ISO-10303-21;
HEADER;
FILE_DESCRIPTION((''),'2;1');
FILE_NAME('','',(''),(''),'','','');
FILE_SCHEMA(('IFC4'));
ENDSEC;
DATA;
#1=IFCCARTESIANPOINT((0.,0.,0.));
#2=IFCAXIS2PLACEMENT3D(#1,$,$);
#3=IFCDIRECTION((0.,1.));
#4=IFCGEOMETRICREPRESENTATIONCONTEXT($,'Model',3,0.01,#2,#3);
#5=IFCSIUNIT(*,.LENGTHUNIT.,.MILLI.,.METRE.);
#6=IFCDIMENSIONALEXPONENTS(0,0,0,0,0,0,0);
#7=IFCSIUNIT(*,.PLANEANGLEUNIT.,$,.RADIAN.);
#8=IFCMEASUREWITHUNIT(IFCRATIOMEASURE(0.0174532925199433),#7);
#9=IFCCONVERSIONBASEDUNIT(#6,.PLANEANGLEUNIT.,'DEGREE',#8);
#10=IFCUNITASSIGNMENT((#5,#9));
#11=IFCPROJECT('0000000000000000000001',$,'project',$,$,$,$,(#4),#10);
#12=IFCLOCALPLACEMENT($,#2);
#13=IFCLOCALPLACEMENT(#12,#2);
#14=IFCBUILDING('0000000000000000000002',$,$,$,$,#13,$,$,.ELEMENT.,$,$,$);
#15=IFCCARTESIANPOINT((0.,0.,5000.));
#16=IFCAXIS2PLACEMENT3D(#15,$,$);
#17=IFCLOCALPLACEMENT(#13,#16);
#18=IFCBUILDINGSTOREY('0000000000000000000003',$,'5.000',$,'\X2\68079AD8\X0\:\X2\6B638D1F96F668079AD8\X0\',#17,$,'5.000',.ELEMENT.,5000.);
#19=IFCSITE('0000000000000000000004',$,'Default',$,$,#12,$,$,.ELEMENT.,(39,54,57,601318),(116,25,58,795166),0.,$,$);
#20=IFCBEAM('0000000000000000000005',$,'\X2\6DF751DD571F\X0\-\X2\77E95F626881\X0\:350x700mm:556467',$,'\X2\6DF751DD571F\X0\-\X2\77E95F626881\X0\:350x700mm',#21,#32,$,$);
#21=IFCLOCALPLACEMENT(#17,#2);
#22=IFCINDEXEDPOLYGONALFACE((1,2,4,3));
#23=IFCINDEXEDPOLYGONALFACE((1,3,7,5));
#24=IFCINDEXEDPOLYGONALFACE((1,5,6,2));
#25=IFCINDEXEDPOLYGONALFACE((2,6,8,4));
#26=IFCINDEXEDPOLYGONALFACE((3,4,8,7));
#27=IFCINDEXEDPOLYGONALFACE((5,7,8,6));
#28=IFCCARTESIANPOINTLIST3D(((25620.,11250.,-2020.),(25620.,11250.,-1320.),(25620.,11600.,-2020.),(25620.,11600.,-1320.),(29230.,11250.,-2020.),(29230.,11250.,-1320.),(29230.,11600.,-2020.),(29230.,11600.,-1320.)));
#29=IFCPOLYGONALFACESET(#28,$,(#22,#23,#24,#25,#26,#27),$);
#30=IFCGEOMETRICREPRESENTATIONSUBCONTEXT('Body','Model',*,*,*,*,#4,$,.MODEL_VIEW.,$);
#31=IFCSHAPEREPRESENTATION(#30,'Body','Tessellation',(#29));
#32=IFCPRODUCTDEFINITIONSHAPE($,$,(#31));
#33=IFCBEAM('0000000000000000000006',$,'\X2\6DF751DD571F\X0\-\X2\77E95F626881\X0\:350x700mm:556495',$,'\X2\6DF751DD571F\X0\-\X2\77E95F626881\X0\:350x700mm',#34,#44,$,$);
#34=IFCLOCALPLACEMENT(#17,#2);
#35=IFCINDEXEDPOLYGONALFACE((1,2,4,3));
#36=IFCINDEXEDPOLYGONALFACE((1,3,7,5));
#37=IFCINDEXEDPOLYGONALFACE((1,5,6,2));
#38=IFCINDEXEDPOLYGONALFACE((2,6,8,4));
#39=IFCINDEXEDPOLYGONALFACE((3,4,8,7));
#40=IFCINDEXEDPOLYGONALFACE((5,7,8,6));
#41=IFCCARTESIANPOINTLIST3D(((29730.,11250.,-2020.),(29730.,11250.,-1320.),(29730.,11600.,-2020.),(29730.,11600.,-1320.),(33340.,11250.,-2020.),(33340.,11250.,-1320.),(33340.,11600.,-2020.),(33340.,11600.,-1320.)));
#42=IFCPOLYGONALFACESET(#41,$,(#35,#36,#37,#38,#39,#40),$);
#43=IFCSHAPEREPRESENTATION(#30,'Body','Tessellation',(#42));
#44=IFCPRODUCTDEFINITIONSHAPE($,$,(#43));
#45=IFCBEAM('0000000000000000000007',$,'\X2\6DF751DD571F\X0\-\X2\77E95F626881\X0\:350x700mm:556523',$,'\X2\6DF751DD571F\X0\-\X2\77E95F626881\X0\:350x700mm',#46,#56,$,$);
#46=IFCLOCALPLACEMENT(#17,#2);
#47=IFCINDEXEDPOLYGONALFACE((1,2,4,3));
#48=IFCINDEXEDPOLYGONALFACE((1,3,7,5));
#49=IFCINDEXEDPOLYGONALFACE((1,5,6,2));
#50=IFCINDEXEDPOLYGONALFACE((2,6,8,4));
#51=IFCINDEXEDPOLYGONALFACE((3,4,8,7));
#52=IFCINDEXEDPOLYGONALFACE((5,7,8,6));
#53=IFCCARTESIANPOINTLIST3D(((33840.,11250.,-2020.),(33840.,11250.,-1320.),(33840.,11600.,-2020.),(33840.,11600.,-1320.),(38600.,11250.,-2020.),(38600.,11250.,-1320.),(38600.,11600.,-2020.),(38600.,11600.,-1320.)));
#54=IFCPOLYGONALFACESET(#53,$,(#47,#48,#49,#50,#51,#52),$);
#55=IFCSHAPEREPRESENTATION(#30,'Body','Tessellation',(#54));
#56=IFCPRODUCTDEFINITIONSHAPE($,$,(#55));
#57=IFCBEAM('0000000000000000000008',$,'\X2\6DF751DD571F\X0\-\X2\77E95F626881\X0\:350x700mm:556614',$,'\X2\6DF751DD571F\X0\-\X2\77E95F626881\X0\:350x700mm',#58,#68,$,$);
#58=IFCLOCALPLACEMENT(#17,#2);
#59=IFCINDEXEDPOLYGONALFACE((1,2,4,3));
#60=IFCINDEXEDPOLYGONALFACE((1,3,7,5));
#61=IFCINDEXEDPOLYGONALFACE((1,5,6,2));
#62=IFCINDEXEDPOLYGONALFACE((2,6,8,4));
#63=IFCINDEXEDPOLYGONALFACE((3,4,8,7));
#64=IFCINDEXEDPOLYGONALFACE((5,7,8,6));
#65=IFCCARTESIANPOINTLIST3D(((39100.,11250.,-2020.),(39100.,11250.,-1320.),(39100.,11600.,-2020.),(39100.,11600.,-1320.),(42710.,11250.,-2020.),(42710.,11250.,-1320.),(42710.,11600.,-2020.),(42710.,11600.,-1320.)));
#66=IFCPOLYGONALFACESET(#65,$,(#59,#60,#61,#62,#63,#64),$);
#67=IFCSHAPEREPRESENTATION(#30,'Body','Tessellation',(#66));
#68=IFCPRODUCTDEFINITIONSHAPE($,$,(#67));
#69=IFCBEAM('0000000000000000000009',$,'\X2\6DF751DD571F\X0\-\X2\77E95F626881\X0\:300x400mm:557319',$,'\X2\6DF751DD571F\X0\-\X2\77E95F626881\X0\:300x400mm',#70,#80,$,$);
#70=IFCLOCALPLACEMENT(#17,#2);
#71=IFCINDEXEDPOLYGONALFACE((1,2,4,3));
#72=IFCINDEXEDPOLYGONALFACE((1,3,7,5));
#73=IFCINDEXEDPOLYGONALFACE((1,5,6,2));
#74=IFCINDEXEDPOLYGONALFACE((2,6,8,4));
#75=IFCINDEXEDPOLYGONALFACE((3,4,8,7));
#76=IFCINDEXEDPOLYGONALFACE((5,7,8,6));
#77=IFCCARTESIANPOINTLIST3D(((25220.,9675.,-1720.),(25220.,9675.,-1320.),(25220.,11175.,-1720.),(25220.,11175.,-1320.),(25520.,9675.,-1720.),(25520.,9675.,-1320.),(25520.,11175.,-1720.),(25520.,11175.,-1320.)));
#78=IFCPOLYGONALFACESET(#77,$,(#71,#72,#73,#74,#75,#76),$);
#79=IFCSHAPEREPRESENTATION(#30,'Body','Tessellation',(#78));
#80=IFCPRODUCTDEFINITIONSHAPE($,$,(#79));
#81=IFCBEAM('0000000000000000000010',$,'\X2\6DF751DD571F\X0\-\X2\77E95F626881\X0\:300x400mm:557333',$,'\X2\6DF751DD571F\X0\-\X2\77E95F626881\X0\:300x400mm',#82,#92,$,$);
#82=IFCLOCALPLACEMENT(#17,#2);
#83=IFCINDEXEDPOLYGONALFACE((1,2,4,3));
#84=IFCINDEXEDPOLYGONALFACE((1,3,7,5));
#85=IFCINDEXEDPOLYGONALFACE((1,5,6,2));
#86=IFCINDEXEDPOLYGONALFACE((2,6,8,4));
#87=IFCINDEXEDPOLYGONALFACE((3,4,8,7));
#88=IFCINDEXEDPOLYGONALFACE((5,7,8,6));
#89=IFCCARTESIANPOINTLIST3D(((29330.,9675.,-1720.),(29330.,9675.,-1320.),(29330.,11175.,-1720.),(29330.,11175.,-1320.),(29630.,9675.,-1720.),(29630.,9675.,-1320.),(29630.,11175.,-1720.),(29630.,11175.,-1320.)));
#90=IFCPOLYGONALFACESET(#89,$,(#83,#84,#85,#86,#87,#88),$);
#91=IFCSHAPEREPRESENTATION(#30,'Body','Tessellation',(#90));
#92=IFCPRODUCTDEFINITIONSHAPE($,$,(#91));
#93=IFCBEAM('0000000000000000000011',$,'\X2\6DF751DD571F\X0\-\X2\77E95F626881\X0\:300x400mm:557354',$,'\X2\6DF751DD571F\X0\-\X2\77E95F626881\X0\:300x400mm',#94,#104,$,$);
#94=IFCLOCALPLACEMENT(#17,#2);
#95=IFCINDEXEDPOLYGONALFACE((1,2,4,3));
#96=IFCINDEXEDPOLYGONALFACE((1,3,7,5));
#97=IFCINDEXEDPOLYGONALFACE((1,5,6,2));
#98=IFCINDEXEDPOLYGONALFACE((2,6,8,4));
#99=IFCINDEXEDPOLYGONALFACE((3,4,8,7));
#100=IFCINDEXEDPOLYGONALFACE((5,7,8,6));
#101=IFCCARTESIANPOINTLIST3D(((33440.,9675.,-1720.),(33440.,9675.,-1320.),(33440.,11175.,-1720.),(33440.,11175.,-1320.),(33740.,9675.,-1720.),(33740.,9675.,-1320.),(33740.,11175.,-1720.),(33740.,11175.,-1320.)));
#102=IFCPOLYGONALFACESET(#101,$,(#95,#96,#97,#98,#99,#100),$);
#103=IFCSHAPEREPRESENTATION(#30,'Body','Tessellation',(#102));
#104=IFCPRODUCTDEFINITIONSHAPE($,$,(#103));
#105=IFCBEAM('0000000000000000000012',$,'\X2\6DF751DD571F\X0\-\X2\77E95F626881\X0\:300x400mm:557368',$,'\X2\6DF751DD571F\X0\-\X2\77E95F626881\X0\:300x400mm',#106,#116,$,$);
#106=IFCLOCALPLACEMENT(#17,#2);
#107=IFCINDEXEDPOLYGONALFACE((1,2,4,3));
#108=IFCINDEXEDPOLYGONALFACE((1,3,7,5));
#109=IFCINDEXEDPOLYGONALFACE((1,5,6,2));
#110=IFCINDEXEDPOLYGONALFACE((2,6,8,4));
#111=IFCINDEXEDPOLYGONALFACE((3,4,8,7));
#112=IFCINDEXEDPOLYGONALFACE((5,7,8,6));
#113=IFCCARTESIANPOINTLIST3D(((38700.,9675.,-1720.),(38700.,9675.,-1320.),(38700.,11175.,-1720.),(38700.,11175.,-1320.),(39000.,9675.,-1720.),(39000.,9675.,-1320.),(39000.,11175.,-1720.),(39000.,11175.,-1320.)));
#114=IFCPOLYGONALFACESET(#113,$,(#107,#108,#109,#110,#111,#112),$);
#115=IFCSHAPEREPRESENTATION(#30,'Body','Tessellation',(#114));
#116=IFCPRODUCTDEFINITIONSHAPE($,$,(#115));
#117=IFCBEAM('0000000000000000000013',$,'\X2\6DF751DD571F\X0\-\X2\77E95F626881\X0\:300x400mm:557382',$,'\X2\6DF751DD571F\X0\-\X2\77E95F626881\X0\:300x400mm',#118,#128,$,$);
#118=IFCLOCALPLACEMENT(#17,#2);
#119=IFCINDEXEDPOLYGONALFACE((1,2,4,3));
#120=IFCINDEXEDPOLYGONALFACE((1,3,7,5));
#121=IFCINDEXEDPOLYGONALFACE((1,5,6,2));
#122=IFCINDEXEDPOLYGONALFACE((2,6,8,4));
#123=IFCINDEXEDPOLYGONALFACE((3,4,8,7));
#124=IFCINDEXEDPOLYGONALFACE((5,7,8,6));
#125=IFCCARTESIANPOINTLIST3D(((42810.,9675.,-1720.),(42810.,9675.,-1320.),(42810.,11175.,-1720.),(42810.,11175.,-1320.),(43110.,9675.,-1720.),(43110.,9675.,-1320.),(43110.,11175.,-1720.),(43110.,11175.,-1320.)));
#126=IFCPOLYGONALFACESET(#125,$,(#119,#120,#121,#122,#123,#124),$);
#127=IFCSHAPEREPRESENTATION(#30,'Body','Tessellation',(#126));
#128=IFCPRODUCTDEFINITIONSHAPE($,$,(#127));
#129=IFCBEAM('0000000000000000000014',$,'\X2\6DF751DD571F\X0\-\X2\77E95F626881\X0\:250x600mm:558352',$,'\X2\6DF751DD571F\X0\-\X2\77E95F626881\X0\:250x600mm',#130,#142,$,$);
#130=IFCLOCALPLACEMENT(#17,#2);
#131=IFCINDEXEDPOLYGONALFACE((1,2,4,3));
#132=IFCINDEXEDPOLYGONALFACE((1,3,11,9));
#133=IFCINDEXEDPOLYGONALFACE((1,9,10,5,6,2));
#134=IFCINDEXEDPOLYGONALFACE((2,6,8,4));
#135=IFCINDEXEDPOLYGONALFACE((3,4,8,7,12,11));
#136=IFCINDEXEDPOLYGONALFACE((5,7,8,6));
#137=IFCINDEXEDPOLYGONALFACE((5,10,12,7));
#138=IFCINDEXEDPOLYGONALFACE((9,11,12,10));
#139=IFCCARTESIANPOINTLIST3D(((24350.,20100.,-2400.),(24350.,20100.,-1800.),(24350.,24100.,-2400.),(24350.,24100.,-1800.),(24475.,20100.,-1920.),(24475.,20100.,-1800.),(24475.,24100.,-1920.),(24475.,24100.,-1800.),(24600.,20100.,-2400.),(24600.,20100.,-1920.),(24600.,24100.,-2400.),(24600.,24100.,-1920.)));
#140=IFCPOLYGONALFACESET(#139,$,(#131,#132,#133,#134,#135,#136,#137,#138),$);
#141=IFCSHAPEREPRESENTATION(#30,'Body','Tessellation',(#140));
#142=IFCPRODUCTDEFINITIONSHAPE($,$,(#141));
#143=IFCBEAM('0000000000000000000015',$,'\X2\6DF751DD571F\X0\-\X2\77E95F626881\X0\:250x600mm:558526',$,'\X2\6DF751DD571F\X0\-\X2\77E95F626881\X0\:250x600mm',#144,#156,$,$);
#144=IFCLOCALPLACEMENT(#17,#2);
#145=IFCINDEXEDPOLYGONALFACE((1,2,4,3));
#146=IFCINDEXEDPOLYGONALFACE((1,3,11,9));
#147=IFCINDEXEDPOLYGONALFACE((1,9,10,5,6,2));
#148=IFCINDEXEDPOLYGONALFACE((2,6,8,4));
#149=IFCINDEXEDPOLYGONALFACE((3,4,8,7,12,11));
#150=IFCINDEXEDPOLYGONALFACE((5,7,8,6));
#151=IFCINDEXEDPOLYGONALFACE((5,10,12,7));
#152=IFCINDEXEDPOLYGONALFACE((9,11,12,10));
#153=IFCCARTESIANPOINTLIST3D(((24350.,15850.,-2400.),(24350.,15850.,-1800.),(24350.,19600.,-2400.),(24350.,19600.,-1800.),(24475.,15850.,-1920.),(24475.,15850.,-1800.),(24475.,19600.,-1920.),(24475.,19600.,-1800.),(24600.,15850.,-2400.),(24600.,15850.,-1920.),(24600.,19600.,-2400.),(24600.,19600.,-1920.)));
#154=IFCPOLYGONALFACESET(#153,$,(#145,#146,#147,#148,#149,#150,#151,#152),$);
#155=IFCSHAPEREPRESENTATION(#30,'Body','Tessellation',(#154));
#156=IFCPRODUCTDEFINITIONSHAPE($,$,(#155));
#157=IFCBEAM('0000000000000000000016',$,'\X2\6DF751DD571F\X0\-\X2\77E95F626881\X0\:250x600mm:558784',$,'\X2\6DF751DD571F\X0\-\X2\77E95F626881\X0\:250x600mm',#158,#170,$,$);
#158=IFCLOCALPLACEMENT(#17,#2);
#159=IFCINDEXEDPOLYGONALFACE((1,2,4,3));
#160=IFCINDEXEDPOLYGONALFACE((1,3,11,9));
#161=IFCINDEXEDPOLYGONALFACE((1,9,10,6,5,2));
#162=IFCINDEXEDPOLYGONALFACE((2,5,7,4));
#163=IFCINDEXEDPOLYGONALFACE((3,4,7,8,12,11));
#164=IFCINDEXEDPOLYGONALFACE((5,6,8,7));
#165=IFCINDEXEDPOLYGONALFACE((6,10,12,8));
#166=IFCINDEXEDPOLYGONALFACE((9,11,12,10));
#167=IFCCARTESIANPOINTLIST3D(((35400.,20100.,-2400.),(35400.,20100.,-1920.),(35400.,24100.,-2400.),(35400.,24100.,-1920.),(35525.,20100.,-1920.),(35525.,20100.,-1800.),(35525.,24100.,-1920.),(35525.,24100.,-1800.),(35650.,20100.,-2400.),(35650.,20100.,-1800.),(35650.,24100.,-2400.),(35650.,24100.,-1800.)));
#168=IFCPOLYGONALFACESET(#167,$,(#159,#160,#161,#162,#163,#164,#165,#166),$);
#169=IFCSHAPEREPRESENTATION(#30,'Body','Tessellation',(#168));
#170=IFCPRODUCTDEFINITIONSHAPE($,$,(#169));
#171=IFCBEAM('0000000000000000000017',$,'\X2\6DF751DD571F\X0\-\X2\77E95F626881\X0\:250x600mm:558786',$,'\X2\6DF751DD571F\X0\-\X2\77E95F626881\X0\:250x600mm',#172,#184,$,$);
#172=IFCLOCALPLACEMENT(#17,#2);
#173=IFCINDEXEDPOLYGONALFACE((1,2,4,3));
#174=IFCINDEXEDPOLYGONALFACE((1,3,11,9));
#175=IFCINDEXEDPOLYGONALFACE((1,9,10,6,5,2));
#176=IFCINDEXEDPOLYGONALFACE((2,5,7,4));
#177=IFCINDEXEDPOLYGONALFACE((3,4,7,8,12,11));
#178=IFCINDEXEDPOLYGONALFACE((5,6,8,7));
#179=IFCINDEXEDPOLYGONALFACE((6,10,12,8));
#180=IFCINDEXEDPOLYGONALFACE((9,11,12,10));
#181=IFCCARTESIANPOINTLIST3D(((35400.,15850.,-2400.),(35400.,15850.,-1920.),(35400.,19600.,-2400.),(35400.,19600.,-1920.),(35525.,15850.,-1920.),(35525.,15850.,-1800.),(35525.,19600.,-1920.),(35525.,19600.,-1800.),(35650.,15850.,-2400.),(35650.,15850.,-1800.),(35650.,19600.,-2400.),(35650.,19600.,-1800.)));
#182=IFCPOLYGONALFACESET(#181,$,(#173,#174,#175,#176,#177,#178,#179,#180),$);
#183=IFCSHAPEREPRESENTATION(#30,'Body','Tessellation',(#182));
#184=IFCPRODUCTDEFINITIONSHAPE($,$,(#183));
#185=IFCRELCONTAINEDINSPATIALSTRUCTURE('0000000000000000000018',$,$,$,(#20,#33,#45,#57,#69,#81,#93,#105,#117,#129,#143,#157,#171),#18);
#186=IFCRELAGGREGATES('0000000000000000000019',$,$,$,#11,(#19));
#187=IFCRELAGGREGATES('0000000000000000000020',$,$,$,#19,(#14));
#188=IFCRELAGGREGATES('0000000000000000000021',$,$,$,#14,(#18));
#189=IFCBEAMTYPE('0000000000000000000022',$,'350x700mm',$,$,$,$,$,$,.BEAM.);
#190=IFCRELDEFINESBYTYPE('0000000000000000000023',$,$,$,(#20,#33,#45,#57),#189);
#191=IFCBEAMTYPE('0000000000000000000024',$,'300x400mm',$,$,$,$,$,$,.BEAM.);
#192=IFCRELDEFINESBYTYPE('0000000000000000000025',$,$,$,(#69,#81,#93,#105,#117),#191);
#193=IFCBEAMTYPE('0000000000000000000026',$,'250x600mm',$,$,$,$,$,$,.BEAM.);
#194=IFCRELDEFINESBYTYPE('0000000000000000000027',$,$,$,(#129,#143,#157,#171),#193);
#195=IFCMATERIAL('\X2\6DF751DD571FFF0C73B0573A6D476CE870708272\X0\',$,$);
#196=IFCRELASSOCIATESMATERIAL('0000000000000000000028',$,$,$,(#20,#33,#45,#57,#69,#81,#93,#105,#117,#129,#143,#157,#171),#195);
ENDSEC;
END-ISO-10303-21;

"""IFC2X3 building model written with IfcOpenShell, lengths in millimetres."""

from ifc_helpers import new_model, entity, si_unit, converted_unit, direction, frame, frame_2d, origin, place, context, subcontext, project, spatial, polyline, rectangle, outline, extrude, material, type_object, element, save


model = new_model("IFC2X3")

# Units and contexts
model_context = context("Model", 3, precision=0.01, world=origin(), true_north=direction((0.0, 1.0)))
body_context = subcontext(model_context, "Body", "Model", "MODEL_VIEW")
ifc_project = project(units=[si_unit("LENGTHUNIT", "METRE", prefix="MILLI"), converted_unit("PLANEANGLEUNIT", "DEGREE", entity("IfcRatioMeasure", 0.0174532925199433), si_unit("PLANEANGLEUNIT", "RADIAN"), dimensions=[0, 0, 0, 0, 0, 0, 0])], contexts=[model_context])

# Site, building, storey
site_placement = place(None, origin())
site = spatial("IfcSite", under=ifc_project, at=site_placement, Name="Default", CompositionType="ELEMENT", RefLatitude=(39, 54, 57, 601318), RefLongitude=(116, 25, 58, 795166), RefElevation=0.0)
building_placement = place(site_placement, origin())
building = spatial("IfcBuilding", under=site, at=building_placement, CompositionType="ELEMENT")
storey_placement = place(building_placement, frame((0.0, 0.0, 5000.0)))
storey = spatial("IfcBuildingStorey", under=building, at=storey_placement, Name="5.000", ObjectType="标高:正负零标高", LongName="5.000", CompositionType="ELEMENT", Elevation=5000.0)

# Beams
ifc_material_1 = material(Name="混凝土，现场浇注灰色")
beam_type_1 = type_object("IfcBeamType", Name="350x700mm", PredefinedType="BEAM")
for number, where, name in (
    (1, (25620.0, 11425.0, -1320.0), "混凝土-矩形梁:350x700mm:556467"),
    (2, (29730.0, 11425.0, -1320.0), "混凝土-矩形梁:350x700mm:556495"),
):
    element("IfcBeam", number, at=place(storey_placement, frame(where)), inside=storey, type_object=beam_type_1, material=ifc_material_1, Name=name, ObjectType="混凝土-矩形梁:350x700mm", context=body_context, shape_type="SweptSolid", body=[
        extrude(rectangle(XDim=700.0, YDim=350.0, at=frame_2d((0.0, 0.0), x_axis=(1.0, 0.0))), frame((0.0, 0.0, -350.0), z_axis=(1.0, 0.0, 0.0), x_axis=(0.0, 0.0, -1.0)), (0.0, 0.0, 1.0), 3610.0),
    ])
beam_1_placement = place(storey_placement, frame((33840.0, 11425.0, -1320.0)))
element("IfcBeam", 3, at=beam_1_placement, inside=storey, type_object=beam_type_1, material=ifc_material_1, Name="混凝土-矩形梁:350x700mm:556523", ObjectType="混凝土-矩形梁:350x700mm", context=body_context, shape_type="SweptSolid", body=[
    extrude(rectangle(XDim=700.0, YDim=350.0, at=frame_2d((0.0, 0.0), x_axis=(1.0, 0.0))), frame((0.0, 0.0, -350.0), z_axis=(1.0, 0.0, 0.0), x_axis=(0.0, 0.0, -1.0)), (0.0, 0.0, 1.0), 4760.0),
])
beam_2_placement = place(storey_placement, frame((39100.0, 11425.0, -1320.0)))
element("IfcBeam", 4, at=beam_2_placement, inside=storey, type_object=beam_type_1, material=ifc_material_1, Name="混凝土-矩形梁:350x700mm:556614", ObjectType="混凝土-矩形梁:350x700mm", context=body_context, shape_type="SweptSolid", body=[
    extrude(rectangle(XDim=700.0, YDim=350.0, at=frame_2d((0.0, 0.0), x_axis=(1.0, 0.0))), frame((0.0, 0.0, -350.0), z_axis=(1.0, 0.0, 0.0), x_axis=(0.0, 0.0, -1.0)), (0.0, 0.0, 1.0), 3610.0),
])
beam_type_2 = type_object("IfcBeamType", Name="300x400mm", PredefinedType="BEAM")
beam_3_placement = place(storey_placement, frame((25370.0, 11175.0, -1320.0), z_axis=(0.0, 0.0, 1.0), x_axis=(0.0, -1.0, 0.0)))
element("IfcBeam", 5, at=beam_3_placement, inside=storey, type_object=beam_type_2, material=ifc_material_1, Name="混凝土-矩形梁:300x400mm:557319", ObjectType="混凝土-矩形梁:300x400mm", context=body_context, shape_type="SweptSolid", body=[
    extrude(rectangle(XDim=400.0, YDim=300.0, at=frame_2d((0.0, 0.0), x_axis=(1.0, 0.0))), frame((0.0, 0.0, -200.0), z_axis=(1.0, 0.0, 0.0), x_axis=(0.0, 0.0, -1.0)), (0.0, 0.0, 1.0), 1500.0),
])
for number, where, z_axis, x_axis, name in (
    (6, (29480.0, 11175.0, -1320.0), (0.0, 0.0, 1.0), (0.0, -1.0, 0.0), "混凝土-矩形梁:300x400mm:557333"),
    (7, (33590.0, 11175.0, -1320.0), (0.0, 0.0, 1.0), (0.0, -1.0, 0.0), "混凝土-矩形梁:300x400mm:557354"),
    (8, (38850.0, 11175.0, -1320.0), (0.0, 0.0, 1.0), (0.0, -1.0, 0.0), "混凝土-矩形梁:300x400mm:557368"),
):
    element("IfcBeam", number, at=place(storey_placement, frame(where, z_axis=z_axis, x_axis=x_axis)), inside=storey, type_object=beam_type_2, material=ifc_material_1, Name=name, ObjectType="混凝土-矩形梁:300x400mm", context=body_context, shape_type="SweptSolid", body=[
        extrude(rectangle(XDim=400.0, YDim=300.0, at=frame_2d((0.0, 0.0), x_axis=(1.0, 0.0))), frame((0.0, 0.0, -200.0), z_axis=(1.0, 0.0, 0.0), x_axis=(0.0, 0.0, -1.0)), (0.0, 0.0, 1.0), 1500.0),
    ])
beam_4_placement = place(storey_placement, frame((42960.0, 11175.0, -1320.0), z_axis=(0.0, 0.0, 1.0), x_axis=(0.0, -1.0, 0.0)))
element("IfcBeam", 9, at=beam_4_placement, inside=storey, type_object=beam_type_2, material=ifc_material_1, Name="混凝土-矩形梁:300x400mm:557382", ObjectType="混凝土-矩形梁:300x400mm", context=body_context, shape_type="SweptSolid", body=[
    extrude(rectangle(XDim=400.0, YDim=300.0, at=frame_2d((0.0, 0.0), x_axis=(1.0, 0.0))), frame((0.0, 0.0, -200.0), z_axis=(1.0, 0.0, 0.0), x_axis=(0.0, 0.0, -1.0)), (0.0, 0.0, 1.0), 1500.0),
])
beam_type_3 = type_object("IfcBeamType", Name="250x600mm", PredefinedType="BEAM")
beam_5_placement = place(storey_placement, frame((24475.0, 24100.0, -1800.0), z_axis=(0.0, 0.0, 1.0), x_axis=(0.0, -1.0, 0.0)))
element("IfcBeam", 10, at=beam_5_placement, inside=storey, type_object=beam_type_3, material=ifc_material_1, Name="混凝土-矩形梁:250x600mm:558352", ObjectType="混凝土-矩形梁:250x600mm", context=body_context, shape_type="SweptSolid", body=[
    extrude(outline(polyline([(-240.0, -125.0), (360.0, -125.0), (360.0, 125.0), (-120.0, 125.0), (-120.0, 0.0), (-240.0, 0.0), (-240.0, -125.0)])), frame((0.0, 0.0, -240.0), z_axis=(1.0, 0.0, 0.0), x_axis=(0.0, 0.0, -1.0)), (0.0, 0.0, 1.0), 4000.0),
])
beam_6_placement = place(storey_placement, frame((24475.0, 19600.0, -1800.0), z_axis=(0.0, 0.0, 1.0), x_axis=(0.0, -1.0, 0.0)))
element("IfcBeam", 11, at=beam_6_placement, inside=storey, type_object=beam_type_3, material=ifc_material_1, Name="混凝土-矩形梁:250x600mm:558526", ObjectType="混凝土-矩形梁:250x600mm", context=body_context, shape_type="SweptSolid", body=[
    extrude(outline(polyline([(-240.0, -125.0), (360.0, -125.0), (360.0, 125.0), (-120.0, 125.0), (-120.0, 0.0), (-240.0, 0.0), (-240.0, -125.0)])), frame((0.0, 0.0, -240.0), z_axis=(1.0, 0.0, 0.0), x_axis=(0.0, 0.0, -1.0)), (0.0, 0.0, 1.0), 3750.0),
])
beam_7_placement = place(storey_placement, frame((35525.0, 24100.0, -1800.0), z_axis=(0.0, 0.0, 1.0), x_axis=(0.0, -1.0, 0.0)))
element("IfcBeam", 12, at=beam_7_placement, inside=storey, type_object=beam_type_3, material=ifc_material_1, Name="混凝土-矩形梁:250x600mm:558784", ObjectType="混凝土-矩形梁:250x600mm", context=body_context, shape_type="SweptSolid", body=[
    extrude(outline(polyline([(-120.0, -125.0), (360.0, -125.0), (360.0, 125.0), (-240.0, 125.0), (-240.0, 0.0), (-120.0, 0.0), (-120.0, -125.0)])), frame((0.0, 0.0, -240.0), z_axis=(1.0, 0.0, 0.0), x_axis=(0.0, 0.0, -1.0)), (0.0, 0.0, 1.0), 4000.0),
])
beam_8_placement = place(storey_placement, frame((35525.0, 19600.0, -1800.0), z_axis=(0.0, 0.0, 1.0), x_axis=(0.0, -1.0, 0.0)))
element("IfcBeam", 13, at=beam_8_placement, inside=storey, type_object=beam_type_3, material=ifc_material_1, Name="混凝土-矩形梁:250x600mm:558786", ObjectType="混凝土-矩形梁:250x600mm", context=body_context, shape_type="SweptSolid", body=[
    extrude(outline(polyline([(-120.0, -125.0), (360.0, -125.0), (360.0, 125.0), (-240.0, 125.0), (-240.0, 0.0), (-120.0, 0.0), (-120.0, -125.0)])), frame((0.0, 0.0, -240.0), z_axis=(1.0, 0.0, 0.0), x_axis=(0.0, 0.0, -1.0)), (0.0, 0.0, 1.0), 3750.0),
])

save(model, "model.ifc")
